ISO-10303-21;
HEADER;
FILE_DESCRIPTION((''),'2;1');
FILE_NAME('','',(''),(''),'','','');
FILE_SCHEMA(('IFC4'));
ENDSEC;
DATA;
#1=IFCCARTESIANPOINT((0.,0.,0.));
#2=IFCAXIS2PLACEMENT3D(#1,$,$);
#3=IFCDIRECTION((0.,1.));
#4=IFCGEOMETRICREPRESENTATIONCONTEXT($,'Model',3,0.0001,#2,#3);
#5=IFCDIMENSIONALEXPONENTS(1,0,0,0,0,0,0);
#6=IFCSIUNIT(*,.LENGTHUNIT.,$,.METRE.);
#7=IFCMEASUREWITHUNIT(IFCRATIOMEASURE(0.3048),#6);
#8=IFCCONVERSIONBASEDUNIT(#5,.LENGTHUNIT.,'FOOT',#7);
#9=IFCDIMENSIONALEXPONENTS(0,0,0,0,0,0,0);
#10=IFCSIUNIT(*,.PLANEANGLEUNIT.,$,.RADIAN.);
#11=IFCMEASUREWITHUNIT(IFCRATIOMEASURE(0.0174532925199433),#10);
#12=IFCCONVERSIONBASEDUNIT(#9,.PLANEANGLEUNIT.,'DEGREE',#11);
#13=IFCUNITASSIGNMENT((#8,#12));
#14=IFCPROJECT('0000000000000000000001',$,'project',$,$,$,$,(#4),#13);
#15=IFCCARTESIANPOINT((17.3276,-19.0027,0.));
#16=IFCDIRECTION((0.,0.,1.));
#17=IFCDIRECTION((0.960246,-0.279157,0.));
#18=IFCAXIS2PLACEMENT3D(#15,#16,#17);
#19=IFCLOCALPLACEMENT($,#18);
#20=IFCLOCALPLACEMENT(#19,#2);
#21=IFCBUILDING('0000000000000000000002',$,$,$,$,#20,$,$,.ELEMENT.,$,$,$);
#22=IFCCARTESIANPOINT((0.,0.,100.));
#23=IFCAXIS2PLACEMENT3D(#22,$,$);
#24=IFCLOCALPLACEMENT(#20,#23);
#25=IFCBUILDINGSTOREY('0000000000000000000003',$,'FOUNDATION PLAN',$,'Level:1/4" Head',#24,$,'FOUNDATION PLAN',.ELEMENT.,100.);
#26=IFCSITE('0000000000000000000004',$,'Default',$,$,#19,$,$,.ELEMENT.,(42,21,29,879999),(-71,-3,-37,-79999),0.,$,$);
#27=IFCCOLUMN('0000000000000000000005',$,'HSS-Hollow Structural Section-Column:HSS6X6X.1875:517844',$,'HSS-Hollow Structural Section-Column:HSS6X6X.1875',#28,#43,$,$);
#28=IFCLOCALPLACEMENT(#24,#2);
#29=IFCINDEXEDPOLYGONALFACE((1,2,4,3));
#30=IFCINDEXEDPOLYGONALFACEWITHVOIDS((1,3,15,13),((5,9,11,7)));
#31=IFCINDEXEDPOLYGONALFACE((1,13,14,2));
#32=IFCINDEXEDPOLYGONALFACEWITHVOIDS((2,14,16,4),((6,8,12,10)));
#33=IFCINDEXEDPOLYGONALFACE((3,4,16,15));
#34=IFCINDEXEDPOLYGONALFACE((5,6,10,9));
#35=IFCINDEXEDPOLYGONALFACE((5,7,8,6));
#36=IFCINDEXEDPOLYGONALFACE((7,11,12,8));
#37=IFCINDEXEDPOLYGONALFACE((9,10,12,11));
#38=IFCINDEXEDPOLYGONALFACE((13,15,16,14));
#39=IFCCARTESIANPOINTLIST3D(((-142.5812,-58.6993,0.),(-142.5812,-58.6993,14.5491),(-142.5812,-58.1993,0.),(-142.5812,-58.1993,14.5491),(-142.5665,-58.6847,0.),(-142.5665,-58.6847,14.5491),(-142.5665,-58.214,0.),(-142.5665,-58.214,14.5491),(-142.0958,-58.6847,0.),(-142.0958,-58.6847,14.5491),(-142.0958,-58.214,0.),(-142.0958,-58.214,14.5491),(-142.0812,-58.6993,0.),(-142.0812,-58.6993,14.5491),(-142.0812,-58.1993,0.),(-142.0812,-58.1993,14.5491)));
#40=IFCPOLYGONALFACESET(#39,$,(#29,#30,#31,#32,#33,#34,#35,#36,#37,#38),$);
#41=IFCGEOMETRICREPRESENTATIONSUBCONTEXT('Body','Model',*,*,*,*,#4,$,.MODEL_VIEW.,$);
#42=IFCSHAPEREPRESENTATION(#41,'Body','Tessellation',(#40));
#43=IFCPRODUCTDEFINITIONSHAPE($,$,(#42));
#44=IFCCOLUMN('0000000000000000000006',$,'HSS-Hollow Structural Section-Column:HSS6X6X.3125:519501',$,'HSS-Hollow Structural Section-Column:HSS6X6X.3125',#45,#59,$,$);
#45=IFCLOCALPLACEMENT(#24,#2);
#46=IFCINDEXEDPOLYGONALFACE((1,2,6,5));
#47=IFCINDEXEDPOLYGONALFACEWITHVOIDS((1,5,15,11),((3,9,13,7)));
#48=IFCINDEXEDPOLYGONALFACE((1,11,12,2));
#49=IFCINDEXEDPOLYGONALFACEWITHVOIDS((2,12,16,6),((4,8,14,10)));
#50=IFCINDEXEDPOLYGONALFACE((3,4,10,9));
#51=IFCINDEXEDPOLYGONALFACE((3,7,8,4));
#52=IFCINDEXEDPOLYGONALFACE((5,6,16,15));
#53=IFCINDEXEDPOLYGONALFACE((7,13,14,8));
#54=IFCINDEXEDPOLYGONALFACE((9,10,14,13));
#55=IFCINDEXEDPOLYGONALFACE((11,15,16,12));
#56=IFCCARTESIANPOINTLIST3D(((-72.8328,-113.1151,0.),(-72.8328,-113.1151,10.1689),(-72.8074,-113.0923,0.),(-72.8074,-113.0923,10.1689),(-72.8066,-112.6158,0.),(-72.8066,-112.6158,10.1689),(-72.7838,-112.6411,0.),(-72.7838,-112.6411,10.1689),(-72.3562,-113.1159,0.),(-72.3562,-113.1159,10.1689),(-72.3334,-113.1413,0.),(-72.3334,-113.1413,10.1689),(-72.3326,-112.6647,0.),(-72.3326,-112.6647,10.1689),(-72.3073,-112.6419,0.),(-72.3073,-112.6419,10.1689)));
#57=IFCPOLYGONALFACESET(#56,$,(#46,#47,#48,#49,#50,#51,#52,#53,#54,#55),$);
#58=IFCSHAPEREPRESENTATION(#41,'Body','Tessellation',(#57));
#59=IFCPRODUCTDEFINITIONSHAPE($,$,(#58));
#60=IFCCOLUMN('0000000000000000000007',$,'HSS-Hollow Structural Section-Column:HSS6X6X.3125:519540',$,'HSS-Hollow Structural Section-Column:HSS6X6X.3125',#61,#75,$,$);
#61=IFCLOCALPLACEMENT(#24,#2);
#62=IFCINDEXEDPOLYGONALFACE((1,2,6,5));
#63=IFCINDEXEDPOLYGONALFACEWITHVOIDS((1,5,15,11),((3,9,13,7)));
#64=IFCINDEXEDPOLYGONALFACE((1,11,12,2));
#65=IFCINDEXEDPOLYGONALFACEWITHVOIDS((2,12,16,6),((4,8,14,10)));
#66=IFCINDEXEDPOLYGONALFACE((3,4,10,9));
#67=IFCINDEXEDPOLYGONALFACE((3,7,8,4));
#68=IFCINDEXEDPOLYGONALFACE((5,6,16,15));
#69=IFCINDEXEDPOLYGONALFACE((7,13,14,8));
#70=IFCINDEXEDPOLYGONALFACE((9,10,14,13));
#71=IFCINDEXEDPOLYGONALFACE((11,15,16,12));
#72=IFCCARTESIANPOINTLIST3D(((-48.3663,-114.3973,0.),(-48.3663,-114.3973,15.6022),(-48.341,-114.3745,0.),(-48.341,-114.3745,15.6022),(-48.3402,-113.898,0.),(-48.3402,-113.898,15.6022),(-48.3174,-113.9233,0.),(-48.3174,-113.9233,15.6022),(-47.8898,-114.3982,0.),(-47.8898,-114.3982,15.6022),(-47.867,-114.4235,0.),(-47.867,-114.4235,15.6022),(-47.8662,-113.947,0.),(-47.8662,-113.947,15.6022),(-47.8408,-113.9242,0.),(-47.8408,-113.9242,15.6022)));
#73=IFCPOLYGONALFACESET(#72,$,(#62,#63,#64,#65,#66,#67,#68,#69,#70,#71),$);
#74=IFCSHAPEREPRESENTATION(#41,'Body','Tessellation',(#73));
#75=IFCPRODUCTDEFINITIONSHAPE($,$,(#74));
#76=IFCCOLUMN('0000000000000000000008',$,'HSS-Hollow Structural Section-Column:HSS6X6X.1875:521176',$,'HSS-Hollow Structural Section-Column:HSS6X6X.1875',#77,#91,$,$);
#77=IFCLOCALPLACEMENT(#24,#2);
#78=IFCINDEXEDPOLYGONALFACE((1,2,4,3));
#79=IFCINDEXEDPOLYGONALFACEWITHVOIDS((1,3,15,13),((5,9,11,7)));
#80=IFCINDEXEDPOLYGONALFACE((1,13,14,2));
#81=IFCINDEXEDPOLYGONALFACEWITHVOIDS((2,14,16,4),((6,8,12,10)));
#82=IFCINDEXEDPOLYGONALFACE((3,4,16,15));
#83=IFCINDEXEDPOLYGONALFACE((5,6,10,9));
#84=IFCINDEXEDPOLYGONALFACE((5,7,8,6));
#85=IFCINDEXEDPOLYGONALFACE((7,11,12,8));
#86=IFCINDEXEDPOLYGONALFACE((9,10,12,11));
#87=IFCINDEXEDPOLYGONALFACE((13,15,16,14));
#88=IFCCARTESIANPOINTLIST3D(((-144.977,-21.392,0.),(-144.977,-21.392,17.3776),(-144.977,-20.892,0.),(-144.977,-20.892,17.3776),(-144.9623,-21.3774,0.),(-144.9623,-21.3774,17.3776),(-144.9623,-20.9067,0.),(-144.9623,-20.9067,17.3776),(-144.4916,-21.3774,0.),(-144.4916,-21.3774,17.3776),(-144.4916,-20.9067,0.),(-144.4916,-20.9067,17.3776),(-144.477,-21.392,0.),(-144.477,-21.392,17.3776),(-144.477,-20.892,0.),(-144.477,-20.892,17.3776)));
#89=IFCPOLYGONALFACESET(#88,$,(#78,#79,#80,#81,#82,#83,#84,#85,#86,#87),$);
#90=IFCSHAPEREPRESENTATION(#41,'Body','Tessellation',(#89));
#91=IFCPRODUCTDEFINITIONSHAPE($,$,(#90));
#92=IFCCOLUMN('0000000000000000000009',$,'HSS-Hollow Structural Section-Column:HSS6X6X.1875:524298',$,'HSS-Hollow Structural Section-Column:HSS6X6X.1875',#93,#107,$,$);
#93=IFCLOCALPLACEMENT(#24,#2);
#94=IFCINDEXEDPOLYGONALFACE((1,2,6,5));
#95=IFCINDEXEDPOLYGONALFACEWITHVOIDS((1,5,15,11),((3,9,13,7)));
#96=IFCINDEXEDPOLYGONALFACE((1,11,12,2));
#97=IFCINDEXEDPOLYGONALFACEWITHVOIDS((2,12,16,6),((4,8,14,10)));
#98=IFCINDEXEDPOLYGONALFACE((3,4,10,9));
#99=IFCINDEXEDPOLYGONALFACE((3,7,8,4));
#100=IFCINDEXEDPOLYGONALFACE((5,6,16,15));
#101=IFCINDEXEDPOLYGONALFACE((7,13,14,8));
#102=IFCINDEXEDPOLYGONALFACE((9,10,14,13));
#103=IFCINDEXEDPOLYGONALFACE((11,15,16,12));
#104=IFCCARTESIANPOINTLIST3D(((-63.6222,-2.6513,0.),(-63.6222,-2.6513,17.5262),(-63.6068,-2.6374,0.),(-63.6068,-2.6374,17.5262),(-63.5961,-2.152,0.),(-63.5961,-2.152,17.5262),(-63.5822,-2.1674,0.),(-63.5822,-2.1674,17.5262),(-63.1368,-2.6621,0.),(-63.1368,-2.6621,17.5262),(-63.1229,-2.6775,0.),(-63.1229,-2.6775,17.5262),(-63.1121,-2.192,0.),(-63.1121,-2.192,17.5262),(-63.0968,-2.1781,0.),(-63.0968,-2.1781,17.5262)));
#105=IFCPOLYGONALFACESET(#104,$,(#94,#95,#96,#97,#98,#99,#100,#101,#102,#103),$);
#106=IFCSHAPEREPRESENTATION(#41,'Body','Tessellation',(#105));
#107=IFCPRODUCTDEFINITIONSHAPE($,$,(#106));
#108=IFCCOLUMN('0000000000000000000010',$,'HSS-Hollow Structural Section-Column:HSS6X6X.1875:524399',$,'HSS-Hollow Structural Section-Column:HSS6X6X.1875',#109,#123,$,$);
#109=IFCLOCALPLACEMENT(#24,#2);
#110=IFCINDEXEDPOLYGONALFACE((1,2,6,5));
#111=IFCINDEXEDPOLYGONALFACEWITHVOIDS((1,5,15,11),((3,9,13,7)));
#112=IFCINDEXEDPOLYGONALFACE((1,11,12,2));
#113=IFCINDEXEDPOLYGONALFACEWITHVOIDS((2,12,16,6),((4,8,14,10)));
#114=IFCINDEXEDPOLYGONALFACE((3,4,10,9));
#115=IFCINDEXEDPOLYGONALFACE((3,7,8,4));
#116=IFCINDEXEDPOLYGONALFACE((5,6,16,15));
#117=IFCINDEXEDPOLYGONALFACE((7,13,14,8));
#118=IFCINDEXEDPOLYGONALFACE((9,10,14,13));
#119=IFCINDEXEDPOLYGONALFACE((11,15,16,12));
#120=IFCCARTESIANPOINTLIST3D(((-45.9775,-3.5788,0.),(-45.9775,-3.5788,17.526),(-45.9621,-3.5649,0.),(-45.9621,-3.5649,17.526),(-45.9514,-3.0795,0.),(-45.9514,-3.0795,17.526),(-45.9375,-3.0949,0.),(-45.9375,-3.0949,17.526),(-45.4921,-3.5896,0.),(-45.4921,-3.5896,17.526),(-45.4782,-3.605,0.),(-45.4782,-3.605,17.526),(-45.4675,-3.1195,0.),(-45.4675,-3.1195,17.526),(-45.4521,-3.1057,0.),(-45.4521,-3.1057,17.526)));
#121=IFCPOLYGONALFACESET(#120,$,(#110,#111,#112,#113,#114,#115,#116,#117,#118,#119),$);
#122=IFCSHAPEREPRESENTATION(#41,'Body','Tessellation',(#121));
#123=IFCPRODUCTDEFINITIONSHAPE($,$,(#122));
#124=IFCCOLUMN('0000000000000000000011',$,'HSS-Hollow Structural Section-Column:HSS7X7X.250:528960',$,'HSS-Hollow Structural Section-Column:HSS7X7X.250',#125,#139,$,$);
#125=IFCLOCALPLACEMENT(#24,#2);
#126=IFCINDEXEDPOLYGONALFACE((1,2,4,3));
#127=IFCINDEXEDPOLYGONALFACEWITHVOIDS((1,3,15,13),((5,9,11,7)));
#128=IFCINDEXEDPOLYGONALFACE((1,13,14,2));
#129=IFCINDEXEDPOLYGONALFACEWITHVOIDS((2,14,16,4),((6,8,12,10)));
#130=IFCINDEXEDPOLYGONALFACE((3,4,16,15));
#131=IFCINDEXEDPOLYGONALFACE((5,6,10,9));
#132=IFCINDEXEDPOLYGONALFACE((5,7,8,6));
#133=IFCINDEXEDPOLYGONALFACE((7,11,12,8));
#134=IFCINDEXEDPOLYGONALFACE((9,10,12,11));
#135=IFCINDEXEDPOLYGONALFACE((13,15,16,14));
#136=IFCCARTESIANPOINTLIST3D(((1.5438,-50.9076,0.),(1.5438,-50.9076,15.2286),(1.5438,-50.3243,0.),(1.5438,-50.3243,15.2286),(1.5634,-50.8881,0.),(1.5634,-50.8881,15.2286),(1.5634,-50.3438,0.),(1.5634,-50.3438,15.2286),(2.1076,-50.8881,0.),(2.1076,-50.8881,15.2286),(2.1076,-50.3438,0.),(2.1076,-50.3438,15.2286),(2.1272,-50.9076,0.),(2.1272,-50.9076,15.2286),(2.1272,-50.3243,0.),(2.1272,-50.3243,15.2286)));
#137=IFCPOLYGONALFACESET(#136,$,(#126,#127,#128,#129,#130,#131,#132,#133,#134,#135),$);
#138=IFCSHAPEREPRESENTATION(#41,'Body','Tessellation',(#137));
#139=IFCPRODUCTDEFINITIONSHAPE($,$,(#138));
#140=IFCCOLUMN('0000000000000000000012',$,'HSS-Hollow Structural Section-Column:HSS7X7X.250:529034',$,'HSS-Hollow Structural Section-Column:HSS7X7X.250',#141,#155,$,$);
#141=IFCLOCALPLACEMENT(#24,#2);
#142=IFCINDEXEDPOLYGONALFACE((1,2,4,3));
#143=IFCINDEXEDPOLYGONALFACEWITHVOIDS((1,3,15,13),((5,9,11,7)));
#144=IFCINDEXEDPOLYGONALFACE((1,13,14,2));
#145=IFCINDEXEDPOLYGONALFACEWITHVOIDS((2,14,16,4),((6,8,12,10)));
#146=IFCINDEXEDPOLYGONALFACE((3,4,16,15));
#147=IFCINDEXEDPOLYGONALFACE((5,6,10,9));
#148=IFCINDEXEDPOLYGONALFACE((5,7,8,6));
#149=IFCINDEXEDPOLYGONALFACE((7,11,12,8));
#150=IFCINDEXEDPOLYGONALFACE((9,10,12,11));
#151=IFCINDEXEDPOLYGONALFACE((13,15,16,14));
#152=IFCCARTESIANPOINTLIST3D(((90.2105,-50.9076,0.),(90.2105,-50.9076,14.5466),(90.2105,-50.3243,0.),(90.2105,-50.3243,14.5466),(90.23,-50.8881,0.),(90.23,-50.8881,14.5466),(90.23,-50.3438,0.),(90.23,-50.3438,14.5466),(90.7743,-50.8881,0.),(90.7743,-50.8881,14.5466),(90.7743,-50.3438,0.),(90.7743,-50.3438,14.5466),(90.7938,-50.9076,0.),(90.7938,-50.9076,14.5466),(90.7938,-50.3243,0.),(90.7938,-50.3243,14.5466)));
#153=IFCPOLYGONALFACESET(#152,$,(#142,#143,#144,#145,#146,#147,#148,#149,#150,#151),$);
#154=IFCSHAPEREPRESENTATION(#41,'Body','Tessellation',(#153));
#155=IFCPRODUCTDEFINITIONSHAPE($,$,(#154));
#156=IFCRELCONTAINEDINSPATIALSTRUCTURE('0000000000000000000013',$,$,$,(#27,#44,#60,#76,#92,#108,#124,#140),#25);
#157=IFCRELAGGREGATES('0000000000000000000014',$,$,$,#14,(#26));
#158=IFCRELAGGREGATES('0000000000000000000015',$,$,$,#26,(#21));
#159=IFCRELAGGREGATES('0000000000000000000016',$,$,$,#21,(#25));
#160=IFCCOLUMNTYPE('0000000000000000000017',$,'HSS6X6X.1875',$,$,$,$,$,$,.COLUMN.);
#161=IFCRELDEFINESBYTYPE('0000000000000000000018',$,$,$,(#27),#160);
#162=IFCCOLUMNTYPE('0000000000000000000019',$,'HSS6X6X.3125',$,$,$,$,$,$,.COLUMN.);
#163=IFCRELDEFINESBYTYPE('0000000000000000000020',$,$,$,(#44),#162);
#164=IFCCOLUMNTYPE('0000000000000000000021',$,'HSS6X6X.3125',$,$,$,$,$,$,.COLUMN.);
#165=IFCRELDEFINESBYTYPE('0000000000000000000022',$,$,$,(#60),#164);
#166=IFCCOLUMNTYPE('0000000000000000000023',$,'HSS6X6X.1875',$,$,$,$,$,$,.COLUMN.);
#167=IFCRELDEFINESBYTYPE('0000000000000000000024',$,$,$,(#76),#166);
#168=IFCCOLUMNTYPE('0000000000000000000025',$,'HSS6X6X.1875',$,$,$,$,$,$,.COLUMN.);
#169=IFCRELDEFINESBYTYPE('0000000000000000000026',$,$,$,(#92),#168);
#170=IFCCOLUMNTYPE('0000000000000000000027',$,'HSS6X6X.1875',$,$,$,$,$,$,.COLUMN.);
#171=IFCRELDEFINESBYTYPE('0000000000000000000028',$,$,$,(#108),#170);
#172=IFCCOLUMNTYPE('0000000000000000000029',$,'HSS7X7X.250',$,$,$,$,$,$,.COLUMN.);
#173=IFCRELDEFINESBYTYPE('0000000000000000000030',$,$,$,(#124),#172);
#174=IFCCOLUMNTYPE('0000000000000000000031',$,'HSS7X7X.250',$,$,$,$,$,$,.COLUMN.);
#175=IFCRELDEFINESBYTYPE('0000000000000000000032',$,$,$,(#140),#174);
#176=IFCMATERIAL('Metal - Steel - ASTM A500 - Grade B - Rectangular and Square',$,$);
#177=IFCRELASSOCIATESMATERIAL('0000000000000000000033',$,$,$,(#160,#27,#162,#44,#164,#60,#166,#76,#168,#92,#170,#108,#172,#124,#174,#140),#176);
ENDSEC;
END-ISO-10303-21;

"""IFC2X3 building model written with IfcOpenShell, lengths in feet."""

from ifc_helpers import new_model, entity, si_unit, converted_unit, direction, frame, frame_2d, origin, origin_2d_with_axis, place, context, subcontext, project, spatial, rectangle, extrude, boolean, source, transform, mapped, material, type_object, type_shapes, element, save


model = new_model("IFC2X3")

# Units and contexts
model_context = context("Model", 3, precision=0.0001, world=origin(), true_north=direction((0.0, 1.0)))
body_context = subcontext(model_context, "Body", "Model", "MODEL_VIEW")
ifc_project = project(units=[converted_unit("LENGTHUNIT", "FOOT", entity("IfcRatioMeasure", 0.3048), si_unit("LENGTHUNIT", "METRE"), dimensions=[1, 0, 0, 0, 0, 0, 0]), converted_unit("PLANEANGLEUNIT", "DEGREE", entity("IfcRatioMeasure", 0.0174532925199433), si_unit("PLANEANGLEUNIT", "RADIAN"), dimensions=[0, 0, 0, 0, 0, 0, 0])], contexts=[model_context])

# Site, building, storey
site_placement = place(None, frame((17.3276, -19.0027, 0.0), z_axis=(0.0, 0.0, 1.0), x_axis=(0.960246, -0.279157, 0.0)))
site = spatial("IfcSite", under=ifc_project, at=site_placement, Name="Default", CompositionType="ELEMENT", RefLatitude=(42, 21, 29, 879999), RefLongitude=(-71, -3, -37, -79999), RefElevation=0.0)
building_placement = place(site_placement, origin())
building = spatial("IfcBuilding", under=site, at=building_placement, CompositionType="ELEMENT")
storey_placement = place(building_placement, frame((0.0, 0.0, 100.0)))
storey = spatial("IfcBuildingStorey", under=building, at=storey_placement, Name="FOUNDATION PLAN", ObjectType="Level:1/4\" Head", LongName="FOUNDATION PLAN", CompositionType="ELEMENT", Elevation=100.0)

# Columns
ifc_material_1 = material(Name="Metal - Steel - ASTM A500 - Grade B - Rectangular and Square")
column_type_1 = type_object("IfcColumnType", Name="HSS6X6X.1875", PredefinedType="COLUMN", material=ifc_material_1)
shared_shape_1 = source(origin(), body_context, "Body", "SweptSolid", [
    boolean("DIFFERENCE", extrude(rectangle(XDim=0.5, YDim=0.5, at=origin_2d_with_axis()), frame((-142.3312, -58.4493, 100.0), z_axis=(0.0, 0.0, 1.0), x_axis=(0.0, -1.0, 0.0)), (0.0, 0.0, 1.0), 14.5491), extrude(rectangle(XDim=0.4707, YDim=0.4707, at=origin_2d_with_axis()), frame((-142.3312, -58.4493, 114.5491), z_axis=(0.0, 0.0, -1.0), x_axis=(0.0, -1.0, 0.0)), (0.0, 0.0, 1.0), 14.5491)),
])
type_shapes(column_type_1, [shared_shape_1])
column_1_placement = place(storey_placement, frame((0.0, 0.0, -100.0)))
element("IfcColumn", 1, at=column_1_placement, inside=storey, type_object=column_type_1, material=ifc_material_1, Name="HSS-Hollow Structural Section-Column:HSS6X6X.1875:517844", ObjectType="HSS-Hollow Structural Section-Column:HSS6X6X.1875", context=body_context, shape_type="MappedRepresentation", body=[
    mapped(shared_shape_1, transform((0.0, 0.0, 0.0), scale=1.0)),
])
column_type_2 = type_object("IfcColumnType", Name="HSS6X6X.3125", PredefinedType="COLUMN", material=ifc_material_1)
shared_shape_2 = source(origin(), body_context, "Body", "SweptSolid", [
    boolean("DIFFERENCE", extrude(rectangle(XDim=0.5, YDim=0.5, at=frame_2d((0.0, 0.0), x_axis=(1.0, 0.0))), frame((-72.57, -112.8785, 100.0), z_axis=(0.0, 0.0, 1.0), x_axis=(-0.99863, 0.052336, 0.0)), (0.0, 0.0, 1.0), 10.1689), extrude(rectangle(XDim=0.4518, YDim=0.4518, at=frame_2d((0.0, 0.0), x_axis=(1.0, 0.0))), frame((-72.57, -112.8785, 110.1689), z_axis=(0.0, 0.0, -1.0), x_axis=(-0.052336, -0.99863, 0.0)), (0.0, 0.0, 1.0), 10.1689)),
])
type_shapes(column_type_2, [shared_shape_2])
column_2_placement = place(storey_placement, frame((0.0, 0.0, -100.0)))
element("IfcColumn", 2, at=column_2_placement, inside=storey, type_object=column_type_2, material=ifc_material_1, Name="HSS-Hollow Structural Section-Column:HSS6X6X.3125:519501", ObjectType="HSS-Hollow Structural Section-Column:HSS6X6X.3125", context=body_context, shape_type="MappedRepresentation", body=[
    mapped(shared_shape_2, transform((0.0, 0.0, 0.0), scale=1.0)),
])
column_type_3 = type_object("IfcColumnType", Name="HSS6X6X.3125", PredefinedType="COLUMN", material=ifc_material_1)
shared_shape_3 = source(origin(), body_context, "Body", "SweptSolid", [
    boolean("DIFFERENCE", extrude(rectangle(XDim=0.5, YDim=0.5, at=frame_2d((0.0, 0.0), x_axis=(1.0, 0.0))), frame((-48.1036, -114.1608, 100.0), z_axis=(0.0, 0.0, 1.0), x_axis=(-0.99863, 0.052336, 0.0)), (0.0, 0.0, 1.0), 15.6022), extrude(rectangle(XDim=0.4518, YDim=0.4518, at=frame_2d((0.0, 0.0), x_axis=(1.0, 0.0))), frame((-48.1036, -114.1608, 115.6022), z_axis=(0.0, 0.0, -1.0), x_axis=(-0.052336, -0.99863, 0.0)), (0.0, 0.0, 1.0), 15.6022)),
])
type_shapes(column_type_3, [shared_shape_3])
column_3_placement = place(storey_placement, frame((0.0, 0.0, -100.0)))
element("IfcColumn", 3, at=column_3_placement, inside=storey, type_object=column_type_3, material=ifc_material_1, Name="HSS-Hollow Structural Section-Column:HSS6X6X.3125:519540", ObjectType="HSS-Hollow Structural Section-Column:HSS6X6X.3125", context=body_context, shape_type="MappedRepresentation", body=[
    mapped(shared_shape_3, transform((0.0, 0.0, 0.0), scale=1.0)),
])
column_type_4 = type_object("IfcColumnType", Name="HSS6X6X.1875", PredefinedType="COLUMN", material=ifc_material_1)
shared_shape_4 = source(origin(), body_context, "Body", "SweptSolid", [
    boolean("DIFFERENCE", extrude(rectangle(XDim=0.5, YDim=0.5, at=origin_2d_with_axis()), frame((-144.727, -21.142, 100.0), z_axis=(0.0, 0.0, 1.0), x_axis=(0.0, -1.0, 0.0)), (0.0, 0.0, 1.0), 17.3776), extrude(rectangle(XDim=0.4707, YDim=0.4707, at=origin_2d_with_axis()), frame((-144.727, -21.142, 117.3776), z_axis=(0.0, 0.0, -1.0), x_axis=(0.0, -1.0, 0.0)), (0.0, 0.0, 1.0), 17.3776)),
])
type_shapes(column_type_4, [shared_shape_4])
column_4_placement = place(storey_placement, frame((0.0, 0.0, -100.0)))
element("IfcColumn", 4, at=column_4_placement, inside=storey, type_object=column_type_4, material=ifc_material_1, Name="HSS-Hollow Structural Section-Column:HSS6X6X.1875:521176", ObjectType="HSS-Hollow Structural Section-Column:HSS6X6X.1875", context=body_context, shape_type="MappedRepresentation", body=[
    mapped(shared_shape_4, transform((0.0, 0.0, 0.0), scale=1.0)),
])
column_type_5 = type_object("IfcColumnType", Name="HSS6X6X.1875", PredefinedType="COLUMN", material=ifc_material_1)
shared_shape_5 = source(origin(), body_context, "Body", "SweptSolid", [
    boolean("DIFFERENCE", extrude(rectangle(XDim=0.5, YDim=0.5, at=origin_2d_with_axis()), frame((-63.3595, -2.4147, 100.0), z_axis=(0.0, 0.0, 1.0), x_axis=(-0.99863, 0.052336, 0.0)), (0.0, 0.0, 1.0), 17.5262), extrude(rectangle(XDim=0.4707, YDim=0.4707, at=frame_2d((0.0, 0.0), x_axis=(1.0, 0.0))), frame((-63.3595, -2.4147, 117.5262), z_axis=(0.0, 0.0, -1.0), x_axis=(-0.052336, -0.99863, 0.0)), (0.0, 0.0, 1.0), 17.5262)),
])
type_shapes(column_type_5, [shared_shape_5])
column_5_placement = place(storey_placement, frame((0.0, 0.0, -100.0)))
element("IfcColumn", 5, at=column_5_placement, inside=storey, type_object=column_type_5, material=ifc_material_1, Name="HSS-Hollow Structural Section-Column:HSS6X6X.1875:524298", ObjectType="HSS-Hollow Structural Section-Column:HSS6X6X.1875", context=body_context, shape_type="MappedRepresentation", body=[
    mapped(shared_shape_5, transform((0.0, 0.0, 0.0), scale=1.0)),
])
column_type_6 = type_object("IfcColumnType", Name="HSS6X6X.1875", PredefinedType="COLUMN", material=ifc_material_1)
shared_shape_6 = source(origin(), body_context, "Body", "SweptSolid", [
    boolean("DIFFERENCE", extrude(rectangle(XDim=0.5, YDim=0.5, at=frame_2d((0.0, 0.0), x_axis=(1.0, 0.0))), frame((-45.7148, -3.3422, 100.0), z_axis=(0.0, 0.0, 1.0), x_axis=(0.052336, 0.99863, 0.0)), (0.0, 0.0, 1.0), 17.526), extrude(rectangle(XDim=0.4707, YDim=0.4707, at=origin_2d_with_axis()), frame((-45.7148, -3.3422, 117.526), z_axis=(0.0, 0.0, -1.0), x_axis=(-0.052336, -0.99863, 0.0)), (0.0, 0.0, 1.0), 17.526)),
])
type_shapes(column_type_6, [shared_shape_6])
column_6_placement = place(storey_placement, frame((0.0, 0.0, -100.0)))
element("IfcColumn", 6, at=column_6_placement, inside=storey, type_object=column_type_6, material=ifc_material_1, Name="HSS-Hollow Structural Section-Column:HSS6X6X.1875:524399", ObjectType="HSS-Hollow Structural Section-Column:HSS6X6X.1875", context=body_context, shape_type="MappedRepresentation", body=[
    mapped(shared_shape_6, transform((0.0, 0.0, 0.0), scale=1.0)),
])
column_type_7 = type_object("IfcColumnType", Name="HSS7X7X.250", PredefinedType="COLUMN", material=ifc_material_1)
shared_shape_7 = source(origin(), body_context, "Body", "SweptSolid", [
    boolean("DIFFERENCE", extrude(rectangle(XDim=0.5833, YDim=0.5833, at=frame_2d((0.0, 0.0), x_axis=(1.0, 0.0))), frame((1.8355, -50.616, 100.0), z_axis=(0.0, 0.0, 1.0), x_axis=(0.0, -1.0, 0.0)), (0.0, 0.0, 1.0), 15.2286), extrude(rectangle(XDim=0.5443, YDim=0.5443, at=frame_2d((0.0, 0.0), x_axis=(1.0, 0.0))), frame((1.8355, -50.616, 115.2286), z_axis=(0.0, 0.0, -1.0), x_axis=(0.0, -1.0, 0.0)), (0.0, 0.0, 1.0), 15.2286)),
])
type_shapes(column_type_7, [shared_shape_7])
column_7_placement = place(storey_placement, frame((0.0, 0.0, -100.0)))
element("IfcColumn", 7, at=column_7_placement, inside=storey, type_object=column_type_7, material=ifc_material_1, Name="HSS-Hollow Structural Section-Column:HSS7X7X.250:528960", ObjectType="HSS-Hollow Structural Section-Column:HSS7X7X.250", context=body_context, shape_type="MappedRepresentation", body=[
    mapped(shared_shape_7, transform((0.0, 0.0, 0.0), scale=1.0)),
])
column_type_8 = type_object("IfcColumnType", Name="HSS7X7X.250", PredefinedType="COLUMN", material=ifc_material_1)
shared_shape_8 = source(origin(), body_context, "Body", "SweptSolid", [
    boolean("DIFFERENCE", extrude(rectangle(XDim=0.5833, YDim=0.5833, at=frame_2d((0.0, 0.0), x_axis=(1.0, 0.0))), frame((90.5022, -50.616, 100.0), z_axis=(0.0, 0.0, 1.0), x_axis=(0.0, -1.0, 0.0)), (0.0, 0.0, 1.0), 14.5466), extrude(rectangle(XDim=0.5443, YDim=0.5443, at=frame_2d((0.0, 0.0), x_axis=(1.0, 0.0))), frame((90.5022, -50.616, 114.5466), z_axis=(0.0, 0.0, -1.0), x_axis=(0.0, -1.0, 0.0)), (0.0, 0.0, 1.0), 14.5466)),
])
type_shapes(column_type_8, [shared_shape_8])
column_8_placement = place(storey_placement, frame((0.0, 0.0, -100.0)))
element("IfcColumn", 8, at=column_8_placement, inside=storey, type_object=column_type_8, material=ifc_material_1, Name="HSS-Hollow Structural Section-Column:HSS7X7X.250:529034", ObjectType="HSS-Hollow Structural Section-Column:HSS7X7X.250", context=body_context, shape_type="MappedRepresentation", body=[
    mapped(shared_shape_8, transform((0.0, 0.0, 0.0), scale=1.0)),
])

save(model, "model.ifc")
